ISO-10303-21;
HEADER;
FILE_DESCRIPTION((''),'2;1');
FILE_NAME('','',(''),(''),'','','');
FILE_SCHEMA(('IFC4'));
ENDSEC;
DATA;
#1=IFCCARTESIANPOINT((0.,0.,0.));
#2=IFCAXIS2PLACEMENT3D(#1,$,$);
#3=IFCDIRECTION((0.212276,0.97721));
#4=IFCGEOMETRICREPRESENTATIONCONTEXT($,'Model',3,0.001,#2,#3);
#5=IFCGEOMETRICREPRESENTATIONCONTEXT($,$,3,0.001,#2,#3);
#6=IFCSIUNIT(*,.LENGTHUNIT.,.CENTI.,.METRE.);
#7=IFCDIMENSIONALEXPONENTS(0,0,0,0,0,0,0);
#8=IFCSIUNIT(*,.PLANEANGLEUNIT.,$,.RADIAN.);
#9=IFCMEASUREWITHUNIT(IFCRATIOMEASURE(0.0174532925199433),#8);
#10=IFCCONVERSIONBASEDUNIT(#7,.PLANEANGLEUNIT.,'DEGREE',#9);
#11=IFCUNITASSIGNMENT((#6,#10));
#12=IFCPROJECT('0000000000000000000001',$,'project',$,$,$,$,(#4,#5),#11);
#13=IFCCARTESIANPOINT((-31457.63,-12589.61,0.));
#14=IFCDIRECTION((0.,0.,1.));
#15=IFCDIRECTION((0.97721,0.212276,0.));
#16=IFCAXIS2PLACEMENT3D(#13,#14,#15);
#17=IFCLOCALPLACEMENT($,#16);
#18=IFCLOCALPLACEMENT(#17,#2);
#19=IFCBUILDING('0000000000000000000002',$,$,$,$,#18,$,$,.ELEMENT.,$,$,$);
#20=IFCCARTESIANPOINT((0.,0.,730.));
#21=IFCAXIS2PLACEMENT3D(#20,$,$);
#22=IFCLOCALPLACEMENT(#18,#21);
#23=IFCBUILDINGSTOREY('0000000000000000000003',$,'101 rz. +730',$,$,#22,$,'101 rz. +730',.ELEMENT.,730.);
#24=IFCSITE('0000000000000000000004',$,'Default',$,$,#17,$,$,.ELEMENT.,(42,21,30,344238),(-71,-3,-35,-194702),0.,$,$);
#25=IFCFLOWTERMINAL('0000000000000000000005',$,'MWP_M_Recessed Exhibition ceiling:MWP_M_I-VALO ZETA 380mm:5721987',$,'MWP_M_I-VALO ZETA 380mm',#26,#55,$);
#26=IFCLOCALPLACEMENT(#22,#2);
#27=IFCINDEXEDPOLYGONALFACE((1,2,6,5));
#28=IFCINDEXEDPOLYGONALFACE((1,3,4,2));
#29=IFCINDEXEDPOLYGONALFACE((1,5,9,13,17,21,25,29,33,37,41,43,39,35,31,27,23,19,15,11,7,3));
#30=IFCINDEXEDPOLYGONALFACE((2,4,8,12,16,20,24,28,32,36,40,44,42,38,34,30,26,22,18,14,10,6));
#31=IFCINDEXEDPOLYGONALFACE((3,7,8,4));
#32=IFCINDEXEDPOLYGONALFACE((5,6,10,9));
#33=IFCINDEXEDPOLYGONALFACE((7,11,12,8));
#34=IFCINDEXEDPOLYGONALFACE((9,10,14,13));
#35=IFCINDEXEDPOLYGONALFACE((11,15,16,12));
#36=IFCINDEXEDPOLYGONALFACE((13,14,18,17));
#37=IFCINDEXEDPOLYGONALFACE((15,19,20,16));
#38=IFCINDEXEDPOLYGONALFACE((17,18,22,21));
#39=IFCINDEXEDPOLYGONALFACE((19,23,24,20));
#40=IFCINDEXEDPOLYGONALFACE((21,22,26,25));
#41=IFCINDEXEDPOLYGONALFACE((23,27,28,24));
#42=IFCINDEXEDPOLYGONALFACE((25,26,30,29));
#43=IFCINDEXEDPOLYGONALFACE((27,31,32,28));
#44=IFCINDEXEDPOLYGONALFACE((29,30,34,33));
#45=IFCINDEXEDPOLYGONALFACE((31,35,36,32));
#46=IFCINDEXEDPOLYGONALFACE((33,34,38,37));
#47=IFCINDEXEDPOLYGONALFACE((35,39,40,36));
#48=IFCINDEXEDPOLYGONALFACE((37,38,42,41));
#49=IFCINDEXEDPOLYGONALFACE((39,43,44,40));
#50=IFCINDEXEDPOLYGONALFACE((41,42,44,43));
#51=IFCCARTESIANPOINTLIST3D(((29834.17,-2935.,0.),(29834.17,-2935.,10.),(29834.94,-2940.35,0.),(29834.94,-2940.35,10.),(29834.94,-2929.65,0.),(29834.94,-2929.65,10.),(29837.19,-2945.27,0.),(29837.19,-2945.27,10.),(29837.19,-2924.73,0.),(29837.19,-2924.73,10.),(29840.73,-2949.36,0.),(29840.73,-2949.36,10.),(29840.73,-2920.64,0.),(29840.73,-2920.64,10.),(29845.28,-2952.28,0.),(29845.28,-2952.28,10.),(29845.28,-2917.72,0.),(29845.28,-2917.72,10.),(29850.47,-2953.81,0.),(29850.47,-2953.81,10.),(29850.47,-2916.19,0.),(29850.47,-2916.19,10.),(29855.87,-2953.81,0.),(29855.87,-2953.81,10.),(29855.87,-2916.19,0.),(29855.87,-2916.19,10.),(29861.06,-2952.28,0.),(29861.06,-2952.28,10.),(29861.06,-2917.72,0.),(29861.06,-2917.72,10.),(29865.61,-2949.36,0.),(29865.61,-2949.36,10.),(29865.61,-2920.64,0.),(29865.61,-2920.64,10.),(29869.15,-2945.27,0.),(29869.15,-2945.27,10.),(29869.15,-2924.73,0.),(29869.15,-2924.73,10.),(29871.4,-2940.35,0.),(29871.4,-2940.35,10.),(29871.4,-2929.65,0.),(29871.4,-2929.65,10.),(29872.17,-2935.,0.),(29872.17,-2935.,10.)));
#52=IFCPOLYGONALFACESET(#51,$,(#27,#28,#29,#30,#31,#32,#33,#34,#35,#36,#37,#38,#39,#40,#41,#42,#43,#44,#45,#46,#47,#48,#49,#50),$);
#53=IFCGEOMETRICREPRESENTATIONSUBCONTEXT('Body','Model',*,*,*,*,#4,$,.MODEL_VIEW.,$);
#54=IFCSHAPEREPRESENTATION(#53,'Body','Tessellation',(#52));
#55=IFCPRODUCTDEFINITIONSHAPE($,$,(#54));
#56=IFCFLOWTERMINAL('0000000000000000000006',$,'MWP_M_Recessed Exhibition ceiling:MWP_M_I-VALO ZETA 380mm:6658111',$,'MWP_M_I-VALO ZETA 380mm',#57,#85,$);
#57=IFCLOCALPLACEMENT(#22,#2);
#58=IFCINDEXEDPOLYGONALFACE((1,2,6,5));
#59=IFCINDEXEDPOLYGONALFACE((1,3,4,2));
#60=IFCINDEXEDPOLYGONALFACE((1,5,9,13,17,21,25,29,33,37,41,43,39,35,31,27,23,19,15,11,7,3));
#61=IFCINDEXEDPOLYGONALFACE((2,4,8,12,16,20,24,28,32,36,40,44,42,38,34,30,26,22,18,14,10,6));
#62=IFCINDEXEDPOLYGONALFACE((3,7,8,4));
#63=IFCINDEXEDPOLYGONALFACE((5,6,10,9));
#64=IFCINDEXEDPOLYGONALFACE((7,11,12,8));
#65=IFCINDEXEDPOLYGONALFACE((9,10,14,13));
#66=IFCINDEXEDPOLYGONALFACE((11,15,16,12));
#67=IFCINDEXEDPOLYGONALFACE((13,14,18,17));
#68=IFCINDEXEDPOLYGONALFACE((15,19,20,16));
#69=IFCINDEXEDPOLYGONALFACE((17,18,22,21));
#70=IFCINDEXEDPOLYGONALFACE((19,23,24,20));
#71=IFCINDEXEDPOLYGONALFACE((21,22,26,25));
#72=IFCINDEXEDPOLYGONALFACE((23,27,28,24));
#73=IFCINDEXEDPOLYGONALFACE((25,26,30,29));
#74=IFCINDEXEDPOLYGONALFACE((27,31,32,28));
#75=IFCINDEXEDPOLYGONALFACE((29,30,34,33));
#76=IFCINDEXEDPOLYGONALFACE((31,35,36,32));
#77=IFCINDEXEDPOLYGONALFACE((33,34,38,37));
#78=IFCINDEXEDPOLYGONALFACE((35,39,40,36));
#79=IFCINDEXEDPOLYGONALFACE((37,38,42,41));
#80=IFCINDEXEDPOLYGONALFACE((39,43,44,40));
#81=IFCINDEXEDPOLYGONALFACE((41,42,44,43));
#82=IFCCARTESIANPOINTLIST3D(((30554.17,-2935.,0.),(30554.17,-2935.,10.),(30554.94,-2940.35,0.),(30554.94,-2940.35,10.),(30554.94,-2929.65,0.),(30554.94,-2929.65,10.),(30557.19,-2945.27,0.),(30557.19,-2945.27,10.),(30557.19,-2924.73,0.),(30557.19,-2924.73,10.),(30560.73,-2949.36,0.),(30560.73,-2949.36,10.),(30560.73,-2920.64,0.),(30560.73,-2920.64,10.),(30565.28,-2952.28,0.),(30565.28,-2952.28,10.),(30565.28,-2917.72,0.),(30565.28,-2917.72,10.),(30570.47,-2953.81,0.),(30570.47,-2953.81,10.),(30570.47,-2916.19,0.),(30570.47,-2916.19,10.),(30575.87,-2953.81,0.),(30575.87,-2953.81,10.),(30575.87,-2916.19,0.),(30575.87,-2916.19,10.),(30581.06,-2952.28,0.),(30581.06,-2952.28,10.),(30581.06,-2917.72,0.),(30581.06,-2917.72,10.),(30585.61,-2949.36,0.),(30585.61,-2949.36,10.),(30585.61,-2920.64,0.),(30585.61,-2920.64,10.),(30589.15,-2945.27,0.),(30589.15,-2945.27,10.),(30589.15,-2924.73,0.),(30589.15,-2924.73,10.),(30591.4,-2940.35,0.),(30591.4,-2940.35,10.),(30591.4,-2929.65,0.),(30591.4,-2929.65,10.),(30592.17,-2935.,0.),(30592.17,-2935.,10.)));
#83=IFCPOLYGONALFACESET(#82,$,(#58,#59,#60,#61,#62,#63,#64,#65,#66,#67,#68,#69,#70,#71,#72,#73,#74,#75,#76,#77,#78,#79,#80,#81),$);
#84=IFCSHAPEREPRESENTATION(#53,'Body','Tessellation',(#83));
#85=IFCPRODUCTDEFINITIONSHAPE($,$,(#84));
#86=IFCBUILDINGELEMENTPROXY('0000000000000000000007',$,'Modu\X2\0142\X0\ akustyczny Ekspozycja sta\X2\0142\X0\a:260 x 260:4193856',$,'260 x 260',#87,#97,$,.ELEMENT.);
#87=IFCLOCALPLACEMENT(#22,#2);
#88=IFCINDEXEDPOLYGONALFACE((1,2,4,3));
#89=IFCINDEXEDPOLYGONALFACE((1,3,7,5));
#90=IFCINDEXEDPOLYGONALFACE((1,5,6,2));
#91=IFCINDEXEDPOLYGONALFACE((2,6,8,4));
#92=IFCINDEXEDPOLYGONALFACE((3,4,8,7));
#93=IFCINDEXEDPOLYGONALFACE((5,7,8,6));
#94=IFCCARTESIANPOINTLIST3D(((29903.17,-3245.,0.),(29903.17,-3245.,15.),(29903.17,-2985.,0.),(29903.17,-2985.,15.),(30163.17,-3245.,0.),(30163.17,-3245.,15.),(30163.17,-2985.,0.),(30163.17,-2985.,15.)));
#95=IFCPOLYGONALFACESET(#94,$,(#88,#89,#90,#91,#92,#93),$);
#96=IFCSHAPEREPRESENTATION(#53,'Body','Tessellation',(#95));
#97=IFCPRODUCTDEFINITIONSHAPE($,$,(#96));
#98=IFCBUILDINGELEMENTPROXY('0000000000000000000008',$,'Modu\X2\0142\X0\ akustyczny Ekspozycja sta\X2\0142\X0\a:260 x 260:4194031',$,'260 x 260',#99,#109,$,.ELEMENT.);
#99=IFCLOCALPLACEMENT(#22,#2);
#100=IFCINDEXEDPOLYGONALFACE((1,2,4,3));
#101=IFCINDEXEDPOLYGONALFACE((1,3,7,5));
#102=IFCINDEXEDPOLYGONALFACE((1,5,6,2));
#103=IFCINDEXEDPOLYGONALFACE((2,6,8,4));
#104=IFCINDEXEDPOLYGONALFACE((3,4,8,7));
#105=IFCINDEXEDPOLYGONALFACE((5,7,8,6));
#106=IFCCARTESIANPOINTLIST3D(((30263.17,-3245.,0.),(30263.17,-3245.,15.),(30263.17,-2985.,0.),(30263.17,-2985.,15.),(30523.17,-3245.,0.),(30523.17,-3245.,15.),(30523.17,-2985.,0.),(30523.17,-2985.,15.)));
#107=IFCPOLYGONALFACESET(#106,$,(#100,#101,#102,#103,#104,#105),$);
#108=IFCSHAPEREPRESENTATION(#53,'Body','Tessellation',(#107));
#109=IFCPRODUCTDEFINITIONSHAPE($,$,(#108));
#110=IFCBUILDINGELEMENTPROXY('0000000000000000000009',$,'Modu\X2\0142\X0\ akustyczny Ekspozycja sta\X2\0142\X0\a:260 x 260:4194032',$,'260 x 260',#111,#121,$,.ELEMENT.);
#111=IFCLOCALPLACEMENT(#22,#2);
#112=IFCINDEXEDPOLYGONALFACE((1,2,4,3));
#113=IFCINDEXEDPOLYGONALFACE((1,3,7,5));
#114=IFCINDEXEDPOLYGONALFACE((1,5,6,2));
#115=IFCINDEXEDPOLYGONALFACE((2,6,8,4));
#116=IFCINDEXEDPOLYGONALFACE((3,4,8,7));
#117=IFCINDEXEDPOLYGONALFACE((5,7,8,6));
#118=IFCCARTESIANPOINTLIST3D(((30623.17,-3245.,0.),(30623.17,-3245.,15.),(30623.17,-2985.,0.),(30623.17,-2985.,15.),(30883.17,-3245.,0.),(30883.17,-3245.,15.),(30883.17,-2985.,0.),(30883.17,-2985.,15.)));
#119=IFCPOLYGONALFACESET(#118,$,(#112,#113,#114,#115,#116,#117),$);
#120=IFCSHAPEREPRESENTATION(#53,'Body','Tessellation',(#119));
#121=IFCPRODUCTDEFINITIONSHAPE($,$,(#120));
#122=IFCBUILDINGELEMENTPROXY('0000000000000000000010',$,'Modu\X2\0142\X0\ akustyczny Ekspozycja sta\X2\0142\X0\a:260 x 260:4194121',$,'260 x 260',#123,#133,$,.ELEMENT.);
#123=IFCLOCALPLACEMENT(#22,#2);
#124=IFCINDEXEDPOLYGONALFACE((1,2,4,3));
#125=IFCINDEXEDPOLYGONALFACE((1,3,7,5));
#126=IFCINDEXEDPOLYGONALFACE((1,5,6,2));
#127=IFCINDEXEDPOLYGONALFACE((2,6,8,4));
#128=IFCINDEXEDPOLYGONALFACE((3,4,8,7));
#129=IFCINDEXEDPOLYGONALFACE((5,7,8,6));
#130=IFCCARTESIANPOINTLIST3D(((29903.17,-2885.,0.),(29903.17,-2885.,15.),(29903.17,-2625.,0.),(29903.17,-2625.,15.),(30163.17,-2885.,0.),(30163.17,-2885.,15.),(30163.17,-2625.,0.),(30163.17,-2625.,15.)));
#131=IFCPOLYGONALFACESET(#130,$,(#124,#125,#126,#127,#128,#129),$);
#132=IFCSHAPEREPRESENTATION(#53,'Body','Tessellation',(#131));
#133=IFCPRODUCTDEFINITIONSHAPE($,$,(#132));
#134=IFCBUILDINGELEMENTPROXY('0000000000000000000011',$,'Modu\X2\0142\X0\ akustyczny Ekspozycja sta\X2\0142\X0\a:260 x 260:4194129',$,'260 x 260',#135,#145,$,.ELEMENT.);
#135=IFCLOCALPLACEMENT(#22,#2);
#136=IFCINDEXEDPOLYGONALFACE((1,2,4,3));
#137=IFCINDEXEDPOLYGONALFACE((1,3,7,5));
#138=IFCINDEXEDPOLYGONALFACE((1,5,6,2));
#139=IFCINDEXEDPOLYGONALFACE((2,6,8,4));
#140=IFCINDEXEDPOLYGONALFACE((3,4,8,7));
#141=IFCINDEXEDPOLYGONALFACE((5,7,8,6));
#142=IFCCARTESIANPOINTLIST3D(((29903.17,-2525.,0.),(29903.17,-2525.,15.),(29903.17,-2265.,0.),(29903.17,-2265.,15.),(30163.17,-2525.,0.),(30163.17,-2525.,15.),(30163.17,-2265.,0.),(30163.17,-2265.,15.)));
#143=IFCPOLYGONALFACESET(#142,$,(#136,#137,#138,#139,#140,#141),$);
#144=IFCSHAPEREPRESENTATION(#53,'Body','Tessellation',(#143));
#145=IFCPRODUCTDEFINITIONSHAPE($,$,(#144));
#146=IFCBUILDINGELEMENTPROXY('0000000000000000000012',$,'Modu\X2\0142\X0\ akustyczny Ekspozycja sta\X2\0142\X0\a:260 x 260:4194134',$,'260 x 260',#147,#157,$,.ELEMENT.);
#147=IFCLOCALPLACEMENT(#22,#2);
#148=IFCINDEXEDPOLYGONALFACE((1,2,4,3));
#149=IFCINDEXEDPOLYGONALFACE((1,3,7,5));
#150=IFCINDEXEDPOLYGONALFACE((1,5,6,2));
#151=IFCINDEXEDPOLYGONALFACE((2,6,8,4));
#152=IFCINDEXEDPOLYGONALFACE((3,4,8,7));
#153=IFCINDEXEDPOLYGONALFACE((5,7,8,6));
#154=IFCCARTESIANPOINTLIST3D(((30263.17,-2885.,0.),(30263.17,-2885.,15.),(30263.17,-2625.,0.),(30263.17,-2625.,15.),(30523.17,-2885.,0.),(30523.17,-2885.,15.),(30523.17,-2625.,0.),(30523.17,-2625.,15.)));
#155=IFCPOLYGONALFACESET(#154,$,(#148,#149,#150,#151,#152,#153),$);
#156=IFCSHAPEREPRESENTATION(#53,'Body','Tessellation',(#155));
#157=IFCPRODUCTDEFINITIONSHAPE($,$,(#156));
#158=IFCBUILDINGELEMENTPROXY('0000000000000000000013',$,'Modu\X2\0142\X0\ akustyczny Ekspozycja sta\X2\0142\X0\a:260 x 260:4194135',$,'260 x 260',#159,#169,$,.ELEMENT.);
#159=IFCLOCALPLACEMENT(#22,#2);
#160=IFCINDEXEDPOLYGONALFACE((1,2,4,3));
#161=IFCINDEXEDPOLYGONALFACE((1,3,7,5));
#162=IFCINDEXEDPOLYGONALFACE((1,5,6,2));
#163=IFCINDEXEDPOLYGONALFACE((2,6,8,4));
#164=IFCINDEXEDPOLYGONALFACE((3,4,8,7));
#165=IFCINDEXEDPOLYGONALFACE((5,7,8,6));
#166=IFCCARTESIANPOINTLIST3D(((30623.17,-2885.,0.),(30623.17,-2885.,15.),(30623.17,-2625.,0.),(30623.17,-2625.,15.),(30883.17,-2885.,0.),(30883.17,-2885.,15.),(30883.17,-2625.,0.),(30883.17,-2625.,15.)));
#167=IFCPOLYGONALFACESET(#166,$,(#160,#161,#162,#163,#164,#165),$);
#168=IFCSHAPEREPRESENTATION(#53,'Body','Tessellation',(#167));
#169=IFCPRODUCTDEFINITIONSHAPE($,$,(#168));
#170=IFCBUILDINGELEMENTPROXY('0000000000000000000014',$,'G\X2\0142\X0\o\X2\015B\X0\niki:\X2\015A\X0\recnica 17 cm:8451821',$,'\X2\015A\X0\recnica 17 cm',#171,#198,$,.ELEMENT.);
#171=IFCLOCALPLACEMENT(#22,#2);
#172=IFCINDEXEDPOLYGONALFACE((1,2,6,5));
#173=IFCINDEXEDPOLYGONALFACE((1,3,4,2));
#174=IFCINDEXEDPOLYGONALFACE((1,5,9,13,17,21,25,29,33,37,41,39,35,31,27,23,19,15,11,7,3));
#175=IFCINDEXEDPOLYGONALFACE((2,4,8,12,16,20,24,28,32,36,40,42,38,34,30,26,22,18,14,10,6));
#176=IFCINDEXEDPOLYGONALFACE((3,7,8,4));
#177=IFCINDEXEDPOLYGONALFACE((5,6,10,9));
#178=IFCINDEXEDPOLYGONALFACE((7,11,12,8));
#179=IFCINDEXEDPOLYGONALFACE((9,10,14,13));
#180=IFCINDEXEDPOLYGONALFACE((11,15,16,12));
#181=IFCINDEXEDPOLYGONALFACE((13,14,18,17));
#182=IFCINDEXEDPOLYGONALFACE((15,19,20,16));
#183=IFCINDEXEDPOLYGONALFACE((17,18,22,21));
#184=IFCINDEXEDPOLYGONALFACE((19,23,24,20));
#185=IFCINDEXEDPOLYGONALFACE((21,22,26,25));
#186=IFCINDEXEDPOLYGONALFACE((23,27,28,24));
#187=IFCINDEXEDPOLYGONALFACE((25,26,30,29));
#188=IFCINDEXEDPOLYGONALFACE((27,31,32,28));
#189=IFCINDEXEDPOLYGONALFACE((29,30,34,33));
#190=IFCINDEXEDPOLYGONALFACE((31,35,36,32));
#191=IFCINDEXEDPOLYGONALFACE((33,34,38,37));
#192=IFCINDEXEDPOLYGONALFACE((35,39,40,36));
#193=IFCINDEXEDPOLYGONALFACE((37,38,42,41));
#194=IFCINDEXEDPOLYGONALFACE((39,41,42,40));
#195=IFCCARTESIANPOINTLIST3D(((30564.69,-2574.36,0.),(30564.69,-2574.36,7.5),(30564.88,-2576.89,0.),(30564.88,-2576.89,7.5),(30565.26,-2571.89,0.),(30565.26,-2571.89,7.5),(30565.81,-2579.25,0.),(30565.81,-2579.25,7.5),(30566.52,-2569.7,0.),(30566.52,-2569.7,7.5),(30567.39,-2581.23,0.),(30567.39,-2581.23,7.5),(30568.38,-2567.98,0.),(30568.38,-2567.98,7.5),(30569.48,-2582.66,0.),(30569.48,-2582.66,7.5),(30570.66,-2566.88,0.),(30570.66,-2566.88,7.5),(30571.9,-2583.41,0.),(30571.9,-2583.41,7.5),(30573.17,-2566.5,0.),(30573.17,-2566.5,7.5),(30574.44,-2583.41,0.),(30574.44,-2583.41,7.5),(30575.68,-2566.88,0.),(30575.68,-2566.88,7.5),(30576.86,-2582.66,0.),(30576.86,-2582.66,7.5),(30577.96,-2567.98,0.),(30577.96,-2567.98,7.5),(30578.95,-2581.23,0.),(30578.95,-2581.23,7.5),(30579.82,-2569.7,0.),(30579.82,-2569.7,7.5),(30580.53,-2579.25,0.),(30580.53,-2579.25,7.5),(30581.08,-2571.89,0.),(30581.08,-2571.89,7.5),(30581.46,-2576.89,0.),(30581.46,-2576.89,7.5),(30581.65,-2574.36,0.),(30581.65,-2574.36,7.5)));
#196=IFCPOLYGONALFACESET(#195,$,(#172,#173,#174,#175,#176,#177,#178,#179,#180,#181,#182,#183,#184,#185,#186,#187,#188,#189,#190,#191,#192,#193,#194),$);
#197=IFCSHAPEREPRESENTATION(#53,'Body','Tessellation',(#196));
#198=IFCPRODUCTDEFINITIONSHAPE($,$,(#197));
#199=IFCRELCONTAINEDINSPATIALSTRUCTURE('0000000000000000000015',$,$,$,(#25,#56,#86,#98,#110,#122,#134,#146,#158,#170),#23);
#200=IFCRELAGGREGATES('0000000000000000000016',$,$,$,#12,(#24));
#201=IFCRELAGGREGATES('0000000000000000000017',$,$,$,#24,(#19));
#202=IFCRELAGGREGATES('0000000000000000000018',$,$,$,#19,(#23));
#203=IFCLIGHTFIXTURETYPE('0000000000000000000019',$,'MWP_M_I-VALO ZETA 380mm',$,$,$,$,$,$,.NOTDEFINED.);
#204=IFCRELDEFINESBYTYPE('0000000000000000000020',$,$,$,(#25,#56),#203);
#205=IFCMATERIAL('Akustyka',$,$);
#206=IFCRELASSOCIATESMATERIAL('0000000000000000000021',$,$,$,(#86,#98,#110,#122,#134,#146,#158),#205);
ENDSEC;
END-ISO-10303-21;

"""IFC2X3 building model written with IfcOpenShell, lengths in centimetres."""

from ifc_helpers import new_model, entity, si_unit, converted_unit, direction, frame, frame_2d, origin, origin_2d_with_axis, place, context, subcontext, project, spatial, rectangle, circle, extrude, source, transform, mapped, material, type_object, type_shapes, element, save


model = new_model("IFC2X3")

# Units and contexts
model_context = context("Model", 3, precision=0.001, world=origin(), true_north=direction((0.212276, 0.97721)))
context_of_model = context(None, 3, precision=0.001, world=origin(), true_north=direction((0.212276, 0.97721)))
body_context = subcontext(model_context, "Body", "Model", "MODEL_VIEW")
ifc_project = project(units=[si_unit("LENGTHUNIT", "METRE", prefix="CENTI"), converted_unit("PLANEANGLEUNIT", "DEGREE", entity("IfcRatioMeasure", 0.0174532925199433), si_unit("PLANEANGLEUNIT", "RADIAN"), dimensions=[0, 0, 0, 0, 0, 0, 0])], contexts=[model_context, context_of_model])

# Site, building, storey
site_placement = place(None, frame((-31457.63, -12589.61, 0.0), z_axis=(0.0, 0.0, 1.0), x_axis=(0.97721, 0.212276, 0.0)))
site = spatial("IfcSite", under=ifc_project, at=site_placement, Name="Default", CompositionType="ELEMENT", RefLatitude=(42, 21, 30, 344238), RefLongitude=(-71, -3, -35, -194702), RefElevation=0.0)
building_placement = place(site_placement, origin())
building = spatial("IfcBuilding", under=site, at=building_placement, CompositionType="ELEMENT")
storey_placement = place(building_placement, frame((0.0, 0.0, 730.0)))
storey = spatial("IfcBuildingStorey", under=building, at=storey_placement, Name="101 rz. +730", LongName="101 rz. +730", CompositionType="ELEMENT", Elevation=730.0)

# Flow terminals
light_fixture_type = type_object("IfcLightFixtureType", Name="MWP_M_I-VALO ZETA 380mm", PredefinedType="NOTDEFINED")
shared_shape_1 = source(origin(), body_context, "Body", "SweptSolid", [
    extrude(circle(Radius=19.0, at=frame_2d((0.0, 0.0), x_axis=(1.0, 0.0))), frame((0.0, 0.0, -10.0)), (0.0, 0.0, 1.0), 10.0),
])
type_shapes(light_fixture_type, [shared_shape_1])
for number, where, z_axis, x_axis, name in (
    (1, (29853.17, -2935.0, 0.0), (0.0, 0.0, -1.0), (1.0, 0.0, 0.0), "MWP_M_Recessed Exhibition ceiling:MWP_M_I-VALO ZETA 380mm:5721987"),
    (2, (30573.17, -2935.0, 0.0), (0.0, 0.0, -1.0), (1.0, 0.0, 0.0), "MWP_M_Recessed Exhibition ceiling:MWP_M_I-VALO ZETA 380mm:6658111"),
):
    element("IfcFlowTerminal", number, at=place(storey_placement, frame(where, z_axis=z_axis, x_axis=x_axis)), inside=storey, type_object=light_fixture_type, Name=name, ObjectType="MWP_M_I-VALO ZETA 380mm", context=body_context, shape_type="MappedRepresentation", body=[
        mapped(shared_shape_1, transform((0.0, 0.0, 0.0), scale=1.0)),
    ])

# Building element proxies
ifc_material_1 = material(Name="Akustyka")
shared_shape_2 = source(origin(), body_context, "Body", "SweptSolid", [
    extrude(rectangle(XDim=260.0, YDim=260.0, at=origin_2d_with_axis()), frame((0.0, 0.0, -15.0), z_axis=(0.0, 0.0, 1.0), x_axis=(-1.0, 0.0, 0.0)), (0.0, 0.0, 1.0), 15.0),
])
for number, where, z_axis, x_axis, name in (
    (3, (30033.17, -3115.0, 0.0), (0.0, 0.0, -1.0), (1.0, 0.0, 0.0), "Moduł akustyczny Ekspozycja stała:260 x 260:4193856"),
    (4, (30393.17, -3115.0, 0.0), (0.0, 0.0, -1.0), (1.0, 0.0, 0.0), "Moduł akustyczny Ekspozycja stała:260 x 260:4194031"),
    (5, (30753.17, -3115.0, 0.0), (0.0, 0.0, -1.0), (1.0, 0.0, 0.0), "Moduł akustyczny Ekspozycja stała:260 x 260:4194032"),
    (6, (30033.17, -2755.0, 0.0), (0.0, 0.0, -1.0), (1.0, 0.0, 0.0), "Moduł akustyczny Ekspozycja stała:260 x 260:4194121"),
    (7, (30033.17, -2395.0, 0.0), (0.0, 0.0, -1.0), (1.0, 0.0, 0.0), "Moduł akustyczny Ekspozycja stała:260 x 260:4194129"),
    (8, (30393.17, -2755.0, 0.0), (0.0, 0.0, -1.0), (1.0, 0.0, 0.0), "Moduł akustyczny Ekspozycja stała:260 x 260:4194134"),
    (9, (30753.17, -2755.0, 0.0), (0.0, 0.0, -1.0), (1.0, 0.0, 0.0), "Moduł akustyczny Ekspozycja stała:260 x 260:4194135"),
):
    element("IfcBuildingElementProxy", number, at=place(storey_placement, frame(where, z_axis=z_axis, x_axis=x_axis)), inside=storey, material=ifc_material_1, Name=name, ObjectType="260 x 260", CompositionType="ELEMENT", context=body_context, shape_type="MappedRepresentation", body=[
        mapped(shared_shape_2, transform((0.0, 0.0, 0.0), scale=1.0)),
    ])
shared_shape_3 = source(origin(), body_context, "Body", "SweptSolid", [
    extrude(circle(Radius=8.5, at=frame_2d((0.0, 0.0), x_axis=(1.0, 0.0))), frame((0.0, 0.0, 0.0), z_axis=(0.0, 0.0, 1.0), x_axis=(0.0, 1.0, 0.0)), (0.0, 0.0, 1.0), 7.5),
])
for number, where, name in (
    (10, (30573.17, -2575.0, 0.0), "Głośniki:Śrecnica 17 cm:8451821"),
):
    element("IfcBuildingElementProxy", number, at=place(storey_placement, frame(where)), inside=storey, Name=name, ObjectType="Śrecnica 17 cm", CompositionType="ELEMENT", context=body_context, shape_type="MappedRepresentation", body=[
        mapped(shared_shape_3, transform((0.0, 0.0, 0.0), scale=1.0)),
    ])

save(model, "model.ifc")
